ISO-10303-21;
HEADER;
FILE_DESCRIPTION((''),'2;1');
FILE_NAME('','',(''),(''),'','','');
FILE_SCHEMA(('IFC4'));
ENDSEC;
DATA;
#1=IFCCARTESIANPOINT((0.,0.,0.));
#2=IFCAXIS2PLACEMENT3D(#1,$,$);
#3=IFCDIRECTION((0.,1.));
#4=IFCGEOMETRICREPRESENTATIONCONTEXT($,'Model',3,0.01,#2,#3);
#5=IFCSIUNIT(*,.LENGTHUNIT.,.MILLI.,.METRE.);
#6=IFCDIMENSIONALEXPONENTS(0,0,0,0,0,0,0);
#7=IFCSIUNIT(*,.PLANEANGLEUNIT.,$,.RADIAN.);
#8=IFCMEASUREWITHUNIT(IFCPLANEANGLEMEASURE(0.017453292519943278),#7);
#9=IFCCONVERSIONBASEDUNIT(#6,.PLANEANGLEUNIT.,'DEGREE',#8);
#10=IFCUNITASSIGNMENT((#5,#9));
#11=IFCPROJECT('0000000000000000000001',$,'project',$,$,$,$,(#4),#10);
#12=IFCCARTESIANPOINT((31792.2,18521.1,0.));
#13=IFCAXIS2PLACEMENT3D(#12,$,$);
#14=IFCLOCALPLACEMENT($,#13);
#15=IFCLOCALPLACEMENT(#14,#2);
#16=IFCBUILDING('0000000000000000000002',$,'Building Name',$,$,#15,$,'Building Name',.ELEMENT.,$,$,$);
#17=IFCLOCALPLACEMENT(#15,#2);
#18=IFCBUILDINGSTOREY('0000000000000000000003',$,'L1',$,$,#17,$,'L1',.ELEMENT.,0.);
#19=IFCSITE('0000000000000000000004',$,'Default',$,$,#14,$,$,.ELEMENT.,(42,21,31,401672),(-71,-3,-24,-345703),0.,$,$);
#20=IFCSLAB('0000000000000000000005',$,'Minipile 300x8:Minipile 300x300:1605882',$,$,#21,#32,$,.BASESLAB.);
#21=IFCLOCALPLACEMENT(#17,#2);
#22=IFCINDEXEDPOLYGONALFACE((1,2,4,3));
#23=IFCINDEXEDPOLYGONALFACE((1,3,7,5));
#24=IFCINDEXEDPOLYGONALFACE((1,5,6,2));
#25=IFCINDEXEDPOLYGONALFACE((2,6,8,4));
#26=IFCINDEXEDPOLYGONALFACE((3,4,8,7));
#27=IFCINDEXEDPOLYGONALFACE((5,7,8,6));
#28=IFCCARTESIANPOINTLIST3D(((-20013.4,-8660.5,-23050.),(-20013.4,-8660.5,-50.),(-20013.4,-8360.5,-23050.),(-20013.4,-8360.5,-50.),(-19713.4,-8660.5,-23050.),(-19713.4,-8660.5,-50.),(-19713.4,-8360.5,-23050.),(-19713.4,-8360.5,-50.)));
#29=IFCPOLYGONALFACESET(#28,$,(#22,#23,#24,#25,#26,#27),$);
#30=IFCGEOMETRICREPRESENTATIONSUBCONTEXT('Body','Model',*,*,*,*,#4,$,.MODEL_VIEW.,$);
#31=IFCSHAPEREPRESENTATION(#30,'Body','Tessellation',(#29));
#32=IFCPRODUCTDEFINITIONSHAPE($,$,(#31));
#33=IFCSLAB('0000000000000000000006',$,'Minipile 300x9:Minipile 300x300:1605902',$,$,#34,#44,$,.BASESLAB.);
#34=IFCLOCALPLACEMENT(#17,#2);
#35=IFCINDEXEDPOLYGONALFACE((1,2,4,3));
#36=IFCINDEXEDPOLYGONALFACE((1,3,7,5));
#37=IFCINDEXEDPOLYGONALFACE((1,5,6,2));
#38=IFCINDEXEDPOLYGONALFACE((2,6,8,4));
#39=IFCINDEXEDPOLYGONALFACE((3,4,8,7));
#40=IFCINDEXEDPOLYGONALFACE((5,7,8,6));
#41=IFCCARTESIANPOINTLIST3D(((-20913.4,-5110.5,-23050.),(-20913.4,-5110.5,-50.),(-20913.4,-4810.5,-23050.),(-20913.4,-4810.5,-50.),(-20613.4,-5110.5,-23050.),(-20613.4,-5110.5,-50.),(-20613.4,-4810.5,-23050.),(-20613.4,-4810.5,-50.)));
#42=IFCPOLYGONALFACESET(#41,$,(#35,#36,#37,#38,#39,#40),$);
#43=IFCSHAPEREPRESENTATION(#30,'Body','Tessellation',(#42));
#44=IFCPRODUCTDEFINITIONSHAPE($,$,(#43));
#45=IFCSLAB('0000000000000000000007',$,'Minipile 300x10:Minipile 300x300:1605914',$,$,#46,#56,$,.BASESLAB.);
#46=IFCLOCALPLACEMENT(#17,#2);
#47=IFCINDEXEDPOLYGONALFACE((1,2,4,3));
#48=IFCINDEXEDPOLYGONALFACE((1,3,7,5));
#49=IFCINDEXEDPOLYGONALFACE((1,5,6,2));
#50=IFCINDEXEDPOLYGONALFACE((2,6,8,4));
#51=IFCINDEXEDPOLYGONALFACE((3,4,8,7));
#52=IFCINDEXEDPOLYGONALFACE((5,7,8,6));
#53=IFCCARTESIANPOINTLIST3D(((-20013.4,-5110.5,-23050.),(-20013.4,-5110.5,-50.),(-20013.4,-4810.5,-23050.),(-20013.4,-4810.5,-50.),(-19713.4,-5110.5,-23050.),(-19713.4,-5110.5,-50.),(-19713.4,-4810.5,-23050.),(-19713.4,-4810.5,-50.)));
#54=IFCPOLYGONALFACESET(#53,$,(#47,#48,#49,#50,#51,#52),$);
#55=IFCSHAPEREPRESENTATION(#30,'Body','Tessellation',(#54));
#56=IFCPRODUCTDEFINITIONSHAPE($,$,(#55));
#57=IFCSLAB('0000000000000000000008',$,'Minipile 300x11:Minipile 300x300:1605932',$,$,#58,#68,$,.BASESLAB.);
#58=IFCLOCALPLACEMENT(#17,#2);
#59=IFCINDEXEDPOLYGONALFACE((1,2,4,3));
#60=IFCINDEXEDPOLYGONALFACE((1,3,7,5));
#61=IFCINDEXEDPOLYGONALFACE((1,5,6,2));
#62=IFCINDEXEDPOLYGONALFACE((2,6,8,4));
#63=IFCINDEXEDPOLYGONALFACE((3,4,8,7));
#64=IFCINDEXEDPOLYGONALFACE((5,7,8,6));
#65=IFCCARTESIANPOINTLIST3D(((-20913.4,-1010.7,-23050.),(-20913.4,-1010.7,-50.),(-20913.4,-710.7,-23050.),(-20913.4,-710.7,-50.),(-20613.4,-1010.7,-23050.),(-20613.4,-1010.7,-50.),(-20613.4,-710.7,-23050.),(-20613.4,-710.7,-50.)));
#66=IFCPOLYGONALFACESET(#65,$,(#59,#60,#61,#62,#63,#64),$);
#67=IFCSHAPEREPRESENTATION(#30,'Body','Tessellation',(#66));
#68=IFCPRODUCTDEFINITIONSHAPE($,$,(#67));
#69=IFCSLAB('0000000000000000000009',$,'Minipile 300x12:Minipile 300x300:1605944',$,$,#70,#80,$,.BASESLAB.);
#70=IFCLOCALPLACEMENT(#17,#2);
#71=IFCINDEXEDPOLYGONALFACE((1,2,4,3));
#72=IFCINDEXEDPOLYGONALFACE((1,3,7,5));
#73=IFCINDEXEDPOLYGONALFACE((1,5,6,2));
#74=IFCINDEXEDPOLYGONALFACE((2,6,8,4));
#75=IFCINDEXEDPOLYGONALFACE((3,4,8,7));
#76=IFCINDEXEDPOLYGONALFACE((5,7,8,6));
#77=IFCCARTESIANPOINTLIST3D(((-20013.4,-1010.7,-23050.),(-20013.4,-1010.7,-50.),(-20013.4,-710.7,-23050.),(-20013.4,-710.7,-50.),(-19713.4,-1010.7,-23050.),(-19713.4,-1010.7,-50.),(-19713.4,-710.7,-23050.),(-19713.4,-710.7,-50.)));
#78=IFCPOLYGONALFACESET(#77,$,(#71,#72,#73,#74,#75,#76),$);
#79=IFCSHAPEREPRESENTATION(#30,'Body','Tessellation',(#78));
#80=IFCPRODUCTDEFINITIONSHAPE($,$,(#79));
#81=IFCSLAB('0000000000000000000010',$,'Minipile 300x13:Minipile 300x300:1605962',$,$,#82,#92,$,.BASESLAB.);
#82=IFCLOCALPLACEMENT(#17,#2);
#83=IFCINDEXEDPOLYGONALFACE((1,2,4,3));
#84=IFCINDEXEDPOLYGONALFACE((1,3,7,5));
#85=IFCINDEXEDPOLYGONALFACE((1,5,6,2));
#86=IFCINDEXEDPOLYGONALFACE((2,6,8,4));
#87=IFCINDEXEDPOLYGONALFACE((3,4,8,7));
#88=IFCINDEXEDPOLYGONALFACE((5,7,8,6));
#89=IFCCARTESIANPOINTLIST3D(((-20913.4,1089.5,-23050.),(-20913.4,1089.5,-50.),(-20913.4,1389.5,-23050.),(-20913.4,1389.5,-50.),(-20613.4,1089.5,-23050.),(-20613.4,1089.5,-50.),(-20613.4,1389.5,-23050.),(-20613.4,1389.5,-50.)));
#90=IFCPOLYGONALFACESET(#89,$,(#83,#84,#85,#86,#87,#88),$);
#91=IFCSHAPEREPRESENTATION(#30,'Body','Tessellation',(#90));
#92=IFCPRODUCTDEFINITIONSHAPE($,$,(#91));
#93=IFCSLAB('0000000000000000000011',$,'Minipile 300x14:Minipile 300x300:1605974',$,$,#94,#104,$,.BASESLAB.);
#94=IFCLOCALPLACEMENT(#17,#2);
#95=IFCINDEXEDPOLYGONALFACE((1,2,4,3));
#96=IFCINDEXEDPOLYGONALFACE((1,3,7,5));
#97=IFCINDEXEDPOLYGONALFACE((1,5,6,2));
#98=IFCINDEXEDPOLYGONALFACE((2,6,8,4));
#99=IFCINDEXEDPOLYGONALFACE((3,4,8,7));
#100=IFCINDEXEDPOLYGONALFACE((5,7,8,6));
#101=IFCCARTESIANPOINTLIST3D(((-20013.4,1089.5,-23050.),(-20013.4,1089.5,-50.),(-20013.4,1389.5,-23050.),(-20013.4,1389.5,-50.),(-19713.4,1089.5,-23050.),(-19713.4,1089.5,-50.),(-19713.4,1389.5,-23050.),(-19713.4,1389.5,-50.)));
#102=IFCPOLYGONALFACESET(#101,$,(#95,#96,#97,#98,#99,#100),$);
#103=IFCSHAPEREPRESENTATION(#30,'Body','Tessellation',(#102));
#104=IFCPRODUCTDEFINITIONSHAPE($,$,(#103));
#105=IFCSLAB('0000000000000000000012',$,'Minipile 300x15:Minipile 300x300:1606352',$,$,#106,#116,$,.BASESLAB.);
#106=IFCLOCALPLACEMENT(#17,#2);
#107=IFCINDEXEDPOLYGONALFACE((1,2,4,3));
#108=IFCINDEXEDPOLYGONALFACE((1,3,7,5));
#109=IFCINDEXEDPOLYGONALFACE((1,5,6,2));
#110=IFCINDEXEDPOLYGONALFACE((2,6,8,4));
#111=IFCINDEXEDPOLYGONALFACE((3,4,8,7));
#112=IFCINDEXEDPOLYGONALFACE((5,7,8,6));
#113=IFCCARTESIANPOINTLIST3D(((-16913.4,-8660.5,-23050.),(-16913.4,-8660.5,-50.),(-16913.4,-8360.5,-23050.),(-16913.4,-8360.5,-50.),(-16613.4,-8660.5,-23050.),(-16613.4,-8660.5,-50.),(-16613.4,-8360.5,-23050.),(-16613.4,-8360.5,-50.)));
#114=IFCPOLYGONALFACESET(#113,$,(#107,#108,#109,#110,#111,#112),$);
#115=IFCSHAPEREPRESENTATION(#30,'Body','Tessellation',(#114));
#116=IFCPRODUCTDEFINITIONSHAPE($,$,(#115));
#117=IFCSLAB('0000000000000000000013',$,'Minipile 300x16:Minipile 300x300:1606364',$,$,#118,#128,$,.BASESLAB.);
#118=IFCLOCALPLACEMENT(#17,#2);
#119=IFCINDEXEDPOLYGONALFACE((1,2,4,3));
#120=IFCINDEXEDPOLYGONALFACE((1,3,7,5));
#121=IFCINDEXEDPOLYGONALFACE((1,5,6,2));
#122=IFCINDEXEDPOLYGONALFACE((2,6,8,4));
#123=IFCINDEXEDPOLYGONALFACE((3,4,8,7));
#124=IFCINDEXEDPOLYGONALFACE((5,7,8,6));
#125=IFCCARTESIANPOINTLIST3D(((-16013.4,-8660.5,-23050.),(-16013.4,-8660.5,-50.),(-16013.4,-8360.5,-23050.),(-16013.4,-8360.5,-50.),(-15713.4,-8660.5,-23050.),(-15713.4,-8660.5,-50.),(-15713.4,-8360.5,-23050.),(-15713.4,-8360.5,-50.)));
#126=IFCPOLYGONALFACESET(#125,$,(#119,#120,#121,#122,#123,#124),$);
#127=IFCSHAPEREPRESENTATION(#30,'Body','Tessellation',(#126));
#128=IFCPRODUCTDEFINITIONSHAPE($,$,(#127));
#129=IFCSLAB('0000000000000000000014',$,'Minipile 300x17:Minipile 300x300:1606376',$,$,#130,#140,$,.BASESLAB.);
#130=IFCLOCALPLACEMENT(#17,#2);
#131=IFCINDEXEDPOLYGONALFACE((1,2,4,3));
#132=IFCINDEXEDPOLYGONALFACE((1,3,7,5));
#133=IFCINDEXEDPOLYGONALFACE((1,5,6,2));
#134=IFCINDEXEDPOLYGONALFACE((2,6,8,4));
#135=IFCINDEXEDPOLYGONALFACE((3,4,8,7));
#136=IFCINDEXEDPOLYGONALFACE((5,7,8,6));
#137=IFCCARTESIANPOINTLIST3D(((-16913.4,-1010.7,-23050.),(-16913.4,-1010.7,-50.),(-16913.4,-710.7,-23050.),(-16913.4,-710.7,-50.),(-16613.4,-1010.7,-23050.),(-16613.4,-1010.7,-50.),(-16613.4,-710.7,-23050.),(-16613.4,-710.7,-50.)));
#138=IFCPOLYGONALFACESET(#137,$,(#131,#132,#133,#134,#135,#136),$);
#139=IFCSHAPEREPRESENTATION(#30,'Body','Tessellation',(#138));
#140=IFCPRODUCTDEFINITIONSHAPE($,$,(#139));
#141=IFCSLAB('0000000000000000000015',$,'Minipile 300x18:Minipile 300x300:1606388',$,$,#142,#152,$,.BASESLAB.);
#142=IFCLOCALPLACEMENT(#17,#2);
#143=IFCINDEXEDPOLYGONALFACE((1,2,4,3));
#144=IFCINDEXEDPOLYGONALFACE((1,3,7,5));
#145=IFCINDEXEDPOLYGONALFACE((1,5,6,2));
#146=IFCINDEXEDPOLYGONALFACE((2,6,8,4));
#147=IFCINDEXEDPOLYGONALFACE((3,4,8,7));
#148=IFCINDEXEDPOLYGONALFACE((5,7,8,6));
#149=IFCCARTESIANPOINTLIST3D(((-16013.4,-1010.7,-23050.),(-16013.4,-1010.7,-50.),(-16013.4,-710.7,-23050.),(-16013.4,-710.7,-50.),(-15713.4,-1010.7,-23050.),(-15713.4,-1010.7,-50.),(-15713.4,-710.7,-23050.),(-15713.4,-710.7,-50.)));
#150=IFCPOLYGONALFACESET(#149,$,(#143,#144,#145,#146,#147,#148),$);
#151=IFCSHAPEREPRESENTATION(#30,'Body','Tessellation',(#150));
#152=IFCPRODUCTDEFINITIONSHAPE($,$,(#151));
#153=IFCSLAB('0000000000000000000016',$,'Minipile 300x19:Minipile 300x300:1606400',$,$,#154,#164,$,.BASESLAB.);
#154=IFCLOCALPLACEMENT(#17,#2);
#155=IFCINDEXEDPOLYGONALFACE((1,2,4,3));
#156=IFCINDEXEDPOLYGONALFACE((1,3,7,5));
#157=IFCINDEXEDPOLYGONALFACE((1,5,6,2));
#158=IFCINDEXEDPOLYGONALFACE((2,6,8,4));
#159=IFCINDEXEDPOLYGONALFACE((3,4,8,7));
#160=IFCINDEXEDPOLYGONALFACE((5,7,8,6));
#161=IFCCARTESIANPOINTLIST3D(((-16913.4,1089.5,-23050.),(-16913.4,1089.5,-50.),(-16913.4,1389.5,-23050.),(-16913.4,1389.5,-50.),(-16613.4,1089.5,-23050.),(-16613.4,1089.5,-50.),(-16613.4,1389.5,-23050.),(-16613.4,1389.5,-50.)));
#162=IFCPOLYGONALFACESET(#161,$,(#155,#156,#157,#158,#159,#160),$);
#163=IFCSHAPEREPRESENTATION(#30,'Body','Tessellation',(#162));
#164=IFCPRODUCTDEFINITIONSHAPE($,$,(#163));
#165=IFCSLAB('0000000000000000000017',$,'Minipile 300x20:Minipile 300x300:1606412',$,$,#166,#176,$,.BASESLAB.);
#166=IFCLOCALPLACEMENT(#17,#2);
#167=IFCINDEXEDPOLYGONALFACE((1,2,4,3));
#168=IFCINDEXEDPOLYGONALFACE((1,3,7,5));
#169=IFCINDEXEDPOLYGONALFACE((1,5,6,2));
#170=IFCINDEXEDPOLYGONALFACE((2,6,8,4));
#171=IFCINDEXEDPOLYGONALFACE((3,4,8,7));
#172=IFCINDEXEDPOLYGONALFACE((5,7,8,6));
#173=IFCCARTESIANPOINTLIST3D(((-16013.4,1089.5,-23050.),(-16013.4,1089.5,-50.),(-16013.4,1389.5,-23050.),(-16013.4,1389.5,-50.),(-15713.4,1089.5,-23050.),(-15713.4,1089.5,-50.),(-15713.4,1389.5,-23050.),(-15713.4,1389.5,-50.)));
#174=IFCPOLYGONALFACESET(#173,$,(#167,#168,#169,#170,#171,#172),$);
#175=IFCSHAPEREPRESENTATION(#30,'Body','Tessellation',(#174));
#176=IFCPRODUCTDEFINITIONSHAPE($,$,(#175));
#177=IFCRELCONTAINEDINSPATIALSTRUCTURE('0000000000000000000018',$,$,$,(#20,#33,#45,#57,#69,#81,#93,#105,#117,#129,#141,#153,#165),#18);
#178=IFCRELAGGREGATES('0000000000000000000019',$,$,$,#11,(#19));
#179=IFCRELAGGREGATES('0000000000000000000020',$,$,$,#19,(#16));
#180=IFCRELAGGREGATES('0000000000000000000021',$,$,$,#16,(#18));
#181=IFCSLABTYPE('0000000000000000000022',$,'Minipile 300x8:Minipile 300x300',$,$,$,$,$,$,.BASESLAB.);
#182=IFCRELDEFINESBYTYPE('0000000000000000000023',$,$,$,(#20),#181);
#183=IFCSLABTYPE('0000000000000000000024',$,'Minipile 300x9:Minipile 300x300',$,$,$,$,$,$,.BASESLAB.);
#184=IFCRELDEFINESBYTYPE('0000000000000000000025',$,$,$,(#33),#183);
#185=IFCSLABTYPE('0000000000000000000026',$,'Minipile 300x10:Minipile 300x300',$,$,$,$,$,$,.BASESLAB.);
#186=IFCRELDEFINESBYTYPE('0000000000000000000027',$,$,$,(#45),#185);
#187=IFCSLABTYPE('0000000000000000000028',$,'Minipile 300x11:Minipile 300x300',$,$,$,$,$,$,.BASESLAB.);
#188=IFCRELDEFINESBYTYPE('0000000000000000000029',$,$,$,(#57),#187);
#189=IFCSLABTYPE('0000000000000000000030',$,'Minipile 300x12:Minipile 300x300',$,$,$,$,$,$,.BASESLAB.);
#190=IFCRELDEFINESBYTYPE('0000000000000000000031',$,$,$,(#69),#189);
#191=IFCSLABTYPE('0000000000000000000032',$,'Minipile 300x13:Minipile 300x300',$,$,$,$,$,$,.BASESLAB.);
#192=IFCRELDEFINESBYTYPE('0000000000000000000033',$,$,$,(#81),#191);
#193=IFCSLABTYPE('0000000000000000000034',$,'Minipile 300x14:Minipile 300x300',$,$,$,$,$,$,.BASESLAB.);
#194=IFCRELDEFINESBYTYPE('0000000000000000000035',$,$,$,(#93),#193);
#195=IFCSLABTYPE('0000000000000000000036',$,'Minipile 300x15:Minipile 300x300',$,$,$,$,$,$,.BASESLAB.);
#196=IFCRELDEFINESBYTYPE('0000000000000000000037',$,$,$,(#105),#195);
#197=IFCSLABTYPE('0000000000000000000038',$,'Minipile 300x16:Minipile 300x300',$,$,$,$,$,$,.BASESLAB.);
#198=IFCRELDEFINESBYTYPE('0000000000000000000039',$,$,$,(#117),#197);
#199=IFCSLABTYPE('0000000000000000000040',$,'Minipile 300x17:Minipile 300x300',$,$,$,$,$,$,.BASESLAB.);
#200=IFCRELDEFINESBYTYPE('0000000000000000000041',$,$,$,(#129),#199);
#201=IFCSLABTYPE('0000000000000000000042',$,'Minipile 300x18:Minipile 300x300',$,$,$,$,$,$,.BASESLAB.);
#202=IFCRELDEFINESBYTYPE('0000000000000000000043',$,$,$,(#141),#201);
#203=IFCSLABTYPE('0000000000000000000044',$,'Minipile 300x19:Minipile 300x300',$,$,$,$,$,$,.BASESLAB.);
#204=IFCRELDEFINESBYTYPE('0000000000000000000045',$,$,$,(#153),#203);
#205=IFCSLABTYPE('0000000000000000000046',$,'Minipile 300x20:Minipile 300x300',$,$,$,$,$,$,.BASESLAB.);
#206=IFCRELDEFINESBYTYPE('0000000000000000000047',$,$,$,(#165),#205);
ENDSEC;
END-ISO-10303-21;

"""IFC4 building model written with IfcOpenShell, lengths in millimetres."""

from ifc_helpers import new_model, entity, si_unit, converted_unit, direction, frame, origin, place, context, subcontext, project, spatial, indexed_curve, outline, extrude, type_object, element, save


model = new_model("IFC4")

# Units and contexts
model_context = context("Model", 3, precision=0.01, world=origin(), true_north=direction((0.0, 1.0)))
body_context = subcontext(model_context, "Body", "Model", "MODEL_VIEW")
ifc_project = project(units=[si_unit("LENGTHUNIT", "METRE", prefix="MILLI"), converted_unit("PLANEANGLEUNIT", "DEGREE", entity("IfcPlaneAngleMeasure", 0.017453292519943278), si_unit("PLANEANGLEUNIT", "RADIAN"), dimensions=[0, 0, 0, 0, 0, 0, 0])], contexts=[model_context])

# Site, building, storey
site_placement = place(None, frame((31792.2, 18521.1, 0.0)))
site = spatial("IfcSite", under=ifc_project, at=site_placement, Name="Default", CompositionType="ELEMENT", RefLatitude=(42, 21, 31, 401672), RefLongitude=(-71, -3, -24, -345703), RefElevation=0.0)
building_placement = place(site_placement, origin())
building = spatial("IfcBuilding", under=site, at=building_placement, Name="Building Name", LongName="Building Name", CompositionType="ELEMENT")
storey_placement = place(building_placement, origin())
storey = spatial("IfcBuildingStorey", under=building, at=storey_placement, Name="L1", LongName="L1", CompositionType="ELEMENT", Elevation=0.0)

# Slabs
slab_type_1 = type_object("IfcSlabType", Name="Minipile 300x8:Minipile 300x300", PredefinedType="BASESLAB")
slab_1_placement = place(storey_placement, origin())
element("IfcSlab", 1, at=slab_1_placement, inside=storey, type_object=slab_type_1, Name="Minipile 300x8:Minipile 300x300:1605882", PredefinedType="BASESLAB", context=body_context, shape_type="SweptSolid", body=[
    extrude(outline(indexed_curve([(-150.0, -150.0), (150.0, -150.0), (150.0, 150.0), (-150.0, 150.0), (-150.0, -150.0)], self_intersect=False)), frame((-19863.4, -8510.5, -23050.0), z_axis=(0.0, 0.0, 1.0), x_axis=(0.0, -1.0, 0.0)), (0.0, 0.0, 1.0), 23000.0),
])
slab_type_2 = type_object("IfcSlabType", Name="Minipile 300x9:Minipile 300x300", PredefinedType="BASESLAB")
slab_2_placement = place(storey_placement, origin())
element("IfcSlab", 2, at=slab_2_placement, inside=storey, type_object=slab_type_2, Name="Minipile 300x9:Minipile 300x300:1605902", PredefinedType="BASESLAB", context=body_context, shape_type="SweptSolid", body=[
    extrude(outline(indexed_curve([(-150.0, -150.0), (150.0, -150.0), (150.0, 150.0), (-150.0, 150.0), (-150.0, -150.0)], self_intersect=False)), frame((-20763.4, -4960.5, -23050.0), z_axis=(0.0, 0.0, 1.0), x_axis=(-1.0, 0.0, 0.0)), (0.0, 0.0, 1.0), 23000.0),
])
slab_type_3 = type_object("IfcSlabType", Name="Minipile 300x10:Minipile 300x300", PredefinedType="BASESLAB")
slab_3_placement = place(storey_placement, origin())
element("IfcSlab", 3, at=slab_3_placement, inside=storey, type_object=slab_type_3, Name="Minipile 300x10:Minipile 300x300:1605914", PredefinedType="BASESLAB", context=body_context, shape_type="SweptSolid", body=[
    extrude(outline(indexed_curve([(-150.0, -150.0), (150.0, -150.0), (150.0, 150.0), (-150.0, 150.0), (-150.0, -150.0)], self_intersect=False)), frame((-19863.4, -4960.5, -23050.0), z_axis=(0.0, 0.0, 1.0), x_axis=(0.0, -1.0, 0.0)), (0.0, 0.0, 1.0), 23000.0),
])
slab_type_4 = type_object("IfcSlabType", Name="Minipile 300x11:Minipile 300x300", PredefinedType="BASESLAB")
slab_4_placement = place(storey_placement, origin())
element("IfcSlab", 4, at=slab_4_placement, inside=storey, type_object=slab_type_4, Name="Minipile 300x11:Minipile 300x300:1605932", PredefinedType="BASESLAB", context=body_context, shape_type="SweptSolid", body=[
    extrude(outline(indexed_curve([(-150.0, -150.0), (150.0, -150.0), (150.0, 150.0), (-150.0, 150.0), (-150.0, -150.0)], self_intersect=False)), frame((-20763.4, -860.7, -23050.0), z_axis=(0.0, 0.0, 1.0), x_axis=(-1.0, 0.0, 0.0)), (0.0, 0.0, 1.0), 23000.0),
])
slab_type_5 = type_object("IfcSlabType", Name="Minipile 300x12:Minipile 300x300", PredefinedType="BASESLAB")
slab_5_placement = place(storey_placement, origin())
element("IfcSlab", 5, at=slab_5_placement, inside=storey, type_object=slab_type_5, Name="Minipile 300x12:Minipile 300x300:1605944", PredefinedType="BASESLAB", context=body_context, shape_type="SweptSolid", body=[
    extrude(outline(indexed_curve([(-150.0, -150.0), (150.0, -150.0), (150.0, 150.0), (-150.0, 150.0), (-150.0, -150.0)], self_intersect=False)), frame((-19863.4, -860.7, -23050.0), z_axis=(0.0, 0.0, 1.0), x_axis=(0.0, -1.0, 0.0)), (0.0, 0.0, 1.0), 23000.0),
])
slab_type_6 = type_object("IfcSlabType", Name="Minipile 300x13:Minipile 300x300", PredefinedType="BASESLAB")
slab_6_placement = place(storey_placement, origin())
element("IfcSlab", 6, at=slab_6_placement, inside=storey, type_object=slab_type_6, Name="Minipile 300x13:Minipile 300x300:1605962", PredefinedType="BASESLAB", context=body_context, shape_type="SweptSolid", body=[
    extrude(outline(indexed_curve([(-150.0, -150.0), (150.0, -150.0), (150.0, 150.0), (-150.0, 150.0), (-150.0, -150.0)], self_intersect=False)), frame((-20763.4, 1239.5, -23050.0), z_axis=(0.0, 0.0, 1.0), x_axis=(-1.0, 0.0, 0.0)), (0.0, 0.0, 1.0), 23000.0),
])
slab_type_7 = type_object("IfcSlabType", Name="Minipile 300x14:Minipile 300x300", PredefinedType="BASESLAB")
slab_7_placement = place(storey_placement, origin())
element("IfcSlab", 7, at=slab_7_placement, inside=storey, type_object=slab_type_7, Name="Minipile 300x14:Minipile 300x300:1605974", PredefinedType="BASESLAB", context=body_context, shape_type="SweptSolid", body=[
    extrude(outline(indexed_curve([(-150.0, -150.0), (150.0, -150.0), (150.0, 150.0), (-150.0, 150.0), (-150.0, -150.0)], self_intersect=False)), frame((-19863.4, 1239.5, -23050.0), z_axis=(0.0, 0.0, 1.0), x_axis=(0.0, -1.0, 0.0)), (0.0, 0.0, 1.0), 23000.0),
])
slab_type_8 = type_object("IfcSlabType", Name="Minipile 300x15:Minipile 300x300", PredefinedType="BASESLAB")
slab_8_placement = place(storey_placement, origin())
element("IfcSlab", 8, at=slab_8_placement, inside=storey, type_object=slab_type_8, Name="Minipile 300x15:Minipile 300x300:1606352", PredefinedType="BASESLAB", context=body_context, shape_type="SweptSolid", body=[
    extrude(outline(indexed_curve([(-150.0, -150.0), (150.0, -150.0), (150.0, 150.0), (-150.0, 150.0), (-150.0, -150.0)], self_intersect=False)), frame((-16763.4, -8510.5, -23050.0), z_axis=(0.0, 0.0, 1.0), x_axis=(-1.0, 0.0, 0.0)), (0.0, 0.0, 1.0), 23000.0),
])
slab_type_9 = type_object("IfcSlabType", Name="Minipile 300x16:Minipile 300x300", PredefinedType="BASESLAB")
slab_9_placement = place(storey_placement, origin())
element("IfcSlab", 9, at=slab_9_placement, inside=storey, type_object=slab_type_9, Name="Minipile 300x16:Minipile 300x300:1606364", PredefinedType="BASESLAB", context=body_context, shape_type="SweptSolid", body=[
    extrude(outline(indexed_curve([(-150.0, -150.0), (150.0, -150.0), (150.0, 150.0), (-150.0, 150.0), (-150.0, -150.0)], self_intersect=False)), frame((-15863.4, -8510.5, -23050.0), z_axis=(0.0, 0.0, 1.0), x_axis=(0.0, -1.0, 0.0)), (0.0, 0.0, 1.0), 23000.0),
])
slab_type_10 = type_object("IfcSlabType", Name="Minipile 300x17:Minipile 300x300", PredefinedType="BASESLAB")
slab_10_placement = place(storey_placement, origin())
element("IfcSlab", 10, at=slab_10_placement, inside=storey, type_object=slab_type_10, Name="Minipile 300x17:Minipile 300x300:1606376", PredefinedType="BASESLAB", context=body_context, shape_type="SweptSolid", body=[
    extrude(outline(indexed_curve([(-150.0, -150.0), (150.0, -150.0), (150.0, 150.0), (-150.0, 150.0), (-150.0, -150.0)], self_intersect=False)), frame((-16763.4, -860.7, -23050.0), z_axis=(0.0, 0.0, 1.0), x_axis=(-1.0, 0.0, 0.0)), (0.0, 0.0, 1.0), 23000.0),
])
slab_type_11 = type_object("IfcSlabType", Name="Minipile 300x18:Minipile 300x300", PredefinedType="BASESLAB")
slab_11_placement = place(storey_placement, origin())
element("IfcSlab", 11, at=slab_11_placement, inside=storey, type_object=slab_type_11, Name="Minipile 300x18:Minipile 300x300:1606388", PredefinedType="BASESLAB", context=body_context, shape_type="SweptSolid", body=[
    extrude(outline(indexed_curve([(-150.0, -150.0), (150.0, -150.0), (150.0, 150.0), (-150.0, 150.0), (-150.0, -150.0)], self_intersect=False)), frame((-15863.4, -860.7, -23050.0), z_axis=(0.0, 0.0, 1.0), x_axis=(0.0, -1.0, 0.0)), (0.0, 0.0, 1.0), 23000.0),
])
slab_type_12 = type_object("IfcSlabType", Name="Minipile 300x19:Minipile 300x300", PredefinedType="BASESLAB")
slab_12_placement = place(storey_placement, origin())
element("IfcSlab", 12, at=slab_12_placement, inside=storey, type_object=slab_type_12, Name="Minipile 300x19:Minipile 300x300:1606400", PredefinedType="BASESLAB", context=body_context, shape_type="SweptSolid", body=[
    extrude(outline(indexed_curve([(-150.0, -150.0), (150.0, -150.0), (150.0, 150.0), (-150.0, 150.0), (-150.0, -150.0)], self_intersect=False)), frame((-16763.4, 1239.5, -23050.0), z_axis=(0.0, 0.0, 1.0), x_axis=(-1.0, 0.0, 0.0)), (0.0, 0.0, 1.0), 23000.0),
])
slab_type_13 = type_object("IfcSlabType", Name="Minipile 300x20:Minipile 300x300", PredefinedType="BASESLAB")
slab_13_placement = place(storey_placement, origin())
element("IfcSlab", 13, at=slab_13_placement, inside=storey, type_object=slab_type_13, Name="Minipile 300x20:Minipile 300x300:1606412", PredefinedType="BASESLAB", context=body_context, shape_type="SweptSolid", body=[
    extrude(outline(indexed_curve([(-150.0, -150.0), (150.0, -150.0), (150.0, 150.0), (-150.0, 150.0), (-150.0, -150.0)], self_intersect=False)), frame((-15863.4, 1239.5, -23050.0), z_axis=(0.0, 0.0, 1.0), x_axis=(0.0, -1.0, 0.0)), (0.0, 0.0, 1.0), 23000.0),
])

save(model, "model.ifc")
